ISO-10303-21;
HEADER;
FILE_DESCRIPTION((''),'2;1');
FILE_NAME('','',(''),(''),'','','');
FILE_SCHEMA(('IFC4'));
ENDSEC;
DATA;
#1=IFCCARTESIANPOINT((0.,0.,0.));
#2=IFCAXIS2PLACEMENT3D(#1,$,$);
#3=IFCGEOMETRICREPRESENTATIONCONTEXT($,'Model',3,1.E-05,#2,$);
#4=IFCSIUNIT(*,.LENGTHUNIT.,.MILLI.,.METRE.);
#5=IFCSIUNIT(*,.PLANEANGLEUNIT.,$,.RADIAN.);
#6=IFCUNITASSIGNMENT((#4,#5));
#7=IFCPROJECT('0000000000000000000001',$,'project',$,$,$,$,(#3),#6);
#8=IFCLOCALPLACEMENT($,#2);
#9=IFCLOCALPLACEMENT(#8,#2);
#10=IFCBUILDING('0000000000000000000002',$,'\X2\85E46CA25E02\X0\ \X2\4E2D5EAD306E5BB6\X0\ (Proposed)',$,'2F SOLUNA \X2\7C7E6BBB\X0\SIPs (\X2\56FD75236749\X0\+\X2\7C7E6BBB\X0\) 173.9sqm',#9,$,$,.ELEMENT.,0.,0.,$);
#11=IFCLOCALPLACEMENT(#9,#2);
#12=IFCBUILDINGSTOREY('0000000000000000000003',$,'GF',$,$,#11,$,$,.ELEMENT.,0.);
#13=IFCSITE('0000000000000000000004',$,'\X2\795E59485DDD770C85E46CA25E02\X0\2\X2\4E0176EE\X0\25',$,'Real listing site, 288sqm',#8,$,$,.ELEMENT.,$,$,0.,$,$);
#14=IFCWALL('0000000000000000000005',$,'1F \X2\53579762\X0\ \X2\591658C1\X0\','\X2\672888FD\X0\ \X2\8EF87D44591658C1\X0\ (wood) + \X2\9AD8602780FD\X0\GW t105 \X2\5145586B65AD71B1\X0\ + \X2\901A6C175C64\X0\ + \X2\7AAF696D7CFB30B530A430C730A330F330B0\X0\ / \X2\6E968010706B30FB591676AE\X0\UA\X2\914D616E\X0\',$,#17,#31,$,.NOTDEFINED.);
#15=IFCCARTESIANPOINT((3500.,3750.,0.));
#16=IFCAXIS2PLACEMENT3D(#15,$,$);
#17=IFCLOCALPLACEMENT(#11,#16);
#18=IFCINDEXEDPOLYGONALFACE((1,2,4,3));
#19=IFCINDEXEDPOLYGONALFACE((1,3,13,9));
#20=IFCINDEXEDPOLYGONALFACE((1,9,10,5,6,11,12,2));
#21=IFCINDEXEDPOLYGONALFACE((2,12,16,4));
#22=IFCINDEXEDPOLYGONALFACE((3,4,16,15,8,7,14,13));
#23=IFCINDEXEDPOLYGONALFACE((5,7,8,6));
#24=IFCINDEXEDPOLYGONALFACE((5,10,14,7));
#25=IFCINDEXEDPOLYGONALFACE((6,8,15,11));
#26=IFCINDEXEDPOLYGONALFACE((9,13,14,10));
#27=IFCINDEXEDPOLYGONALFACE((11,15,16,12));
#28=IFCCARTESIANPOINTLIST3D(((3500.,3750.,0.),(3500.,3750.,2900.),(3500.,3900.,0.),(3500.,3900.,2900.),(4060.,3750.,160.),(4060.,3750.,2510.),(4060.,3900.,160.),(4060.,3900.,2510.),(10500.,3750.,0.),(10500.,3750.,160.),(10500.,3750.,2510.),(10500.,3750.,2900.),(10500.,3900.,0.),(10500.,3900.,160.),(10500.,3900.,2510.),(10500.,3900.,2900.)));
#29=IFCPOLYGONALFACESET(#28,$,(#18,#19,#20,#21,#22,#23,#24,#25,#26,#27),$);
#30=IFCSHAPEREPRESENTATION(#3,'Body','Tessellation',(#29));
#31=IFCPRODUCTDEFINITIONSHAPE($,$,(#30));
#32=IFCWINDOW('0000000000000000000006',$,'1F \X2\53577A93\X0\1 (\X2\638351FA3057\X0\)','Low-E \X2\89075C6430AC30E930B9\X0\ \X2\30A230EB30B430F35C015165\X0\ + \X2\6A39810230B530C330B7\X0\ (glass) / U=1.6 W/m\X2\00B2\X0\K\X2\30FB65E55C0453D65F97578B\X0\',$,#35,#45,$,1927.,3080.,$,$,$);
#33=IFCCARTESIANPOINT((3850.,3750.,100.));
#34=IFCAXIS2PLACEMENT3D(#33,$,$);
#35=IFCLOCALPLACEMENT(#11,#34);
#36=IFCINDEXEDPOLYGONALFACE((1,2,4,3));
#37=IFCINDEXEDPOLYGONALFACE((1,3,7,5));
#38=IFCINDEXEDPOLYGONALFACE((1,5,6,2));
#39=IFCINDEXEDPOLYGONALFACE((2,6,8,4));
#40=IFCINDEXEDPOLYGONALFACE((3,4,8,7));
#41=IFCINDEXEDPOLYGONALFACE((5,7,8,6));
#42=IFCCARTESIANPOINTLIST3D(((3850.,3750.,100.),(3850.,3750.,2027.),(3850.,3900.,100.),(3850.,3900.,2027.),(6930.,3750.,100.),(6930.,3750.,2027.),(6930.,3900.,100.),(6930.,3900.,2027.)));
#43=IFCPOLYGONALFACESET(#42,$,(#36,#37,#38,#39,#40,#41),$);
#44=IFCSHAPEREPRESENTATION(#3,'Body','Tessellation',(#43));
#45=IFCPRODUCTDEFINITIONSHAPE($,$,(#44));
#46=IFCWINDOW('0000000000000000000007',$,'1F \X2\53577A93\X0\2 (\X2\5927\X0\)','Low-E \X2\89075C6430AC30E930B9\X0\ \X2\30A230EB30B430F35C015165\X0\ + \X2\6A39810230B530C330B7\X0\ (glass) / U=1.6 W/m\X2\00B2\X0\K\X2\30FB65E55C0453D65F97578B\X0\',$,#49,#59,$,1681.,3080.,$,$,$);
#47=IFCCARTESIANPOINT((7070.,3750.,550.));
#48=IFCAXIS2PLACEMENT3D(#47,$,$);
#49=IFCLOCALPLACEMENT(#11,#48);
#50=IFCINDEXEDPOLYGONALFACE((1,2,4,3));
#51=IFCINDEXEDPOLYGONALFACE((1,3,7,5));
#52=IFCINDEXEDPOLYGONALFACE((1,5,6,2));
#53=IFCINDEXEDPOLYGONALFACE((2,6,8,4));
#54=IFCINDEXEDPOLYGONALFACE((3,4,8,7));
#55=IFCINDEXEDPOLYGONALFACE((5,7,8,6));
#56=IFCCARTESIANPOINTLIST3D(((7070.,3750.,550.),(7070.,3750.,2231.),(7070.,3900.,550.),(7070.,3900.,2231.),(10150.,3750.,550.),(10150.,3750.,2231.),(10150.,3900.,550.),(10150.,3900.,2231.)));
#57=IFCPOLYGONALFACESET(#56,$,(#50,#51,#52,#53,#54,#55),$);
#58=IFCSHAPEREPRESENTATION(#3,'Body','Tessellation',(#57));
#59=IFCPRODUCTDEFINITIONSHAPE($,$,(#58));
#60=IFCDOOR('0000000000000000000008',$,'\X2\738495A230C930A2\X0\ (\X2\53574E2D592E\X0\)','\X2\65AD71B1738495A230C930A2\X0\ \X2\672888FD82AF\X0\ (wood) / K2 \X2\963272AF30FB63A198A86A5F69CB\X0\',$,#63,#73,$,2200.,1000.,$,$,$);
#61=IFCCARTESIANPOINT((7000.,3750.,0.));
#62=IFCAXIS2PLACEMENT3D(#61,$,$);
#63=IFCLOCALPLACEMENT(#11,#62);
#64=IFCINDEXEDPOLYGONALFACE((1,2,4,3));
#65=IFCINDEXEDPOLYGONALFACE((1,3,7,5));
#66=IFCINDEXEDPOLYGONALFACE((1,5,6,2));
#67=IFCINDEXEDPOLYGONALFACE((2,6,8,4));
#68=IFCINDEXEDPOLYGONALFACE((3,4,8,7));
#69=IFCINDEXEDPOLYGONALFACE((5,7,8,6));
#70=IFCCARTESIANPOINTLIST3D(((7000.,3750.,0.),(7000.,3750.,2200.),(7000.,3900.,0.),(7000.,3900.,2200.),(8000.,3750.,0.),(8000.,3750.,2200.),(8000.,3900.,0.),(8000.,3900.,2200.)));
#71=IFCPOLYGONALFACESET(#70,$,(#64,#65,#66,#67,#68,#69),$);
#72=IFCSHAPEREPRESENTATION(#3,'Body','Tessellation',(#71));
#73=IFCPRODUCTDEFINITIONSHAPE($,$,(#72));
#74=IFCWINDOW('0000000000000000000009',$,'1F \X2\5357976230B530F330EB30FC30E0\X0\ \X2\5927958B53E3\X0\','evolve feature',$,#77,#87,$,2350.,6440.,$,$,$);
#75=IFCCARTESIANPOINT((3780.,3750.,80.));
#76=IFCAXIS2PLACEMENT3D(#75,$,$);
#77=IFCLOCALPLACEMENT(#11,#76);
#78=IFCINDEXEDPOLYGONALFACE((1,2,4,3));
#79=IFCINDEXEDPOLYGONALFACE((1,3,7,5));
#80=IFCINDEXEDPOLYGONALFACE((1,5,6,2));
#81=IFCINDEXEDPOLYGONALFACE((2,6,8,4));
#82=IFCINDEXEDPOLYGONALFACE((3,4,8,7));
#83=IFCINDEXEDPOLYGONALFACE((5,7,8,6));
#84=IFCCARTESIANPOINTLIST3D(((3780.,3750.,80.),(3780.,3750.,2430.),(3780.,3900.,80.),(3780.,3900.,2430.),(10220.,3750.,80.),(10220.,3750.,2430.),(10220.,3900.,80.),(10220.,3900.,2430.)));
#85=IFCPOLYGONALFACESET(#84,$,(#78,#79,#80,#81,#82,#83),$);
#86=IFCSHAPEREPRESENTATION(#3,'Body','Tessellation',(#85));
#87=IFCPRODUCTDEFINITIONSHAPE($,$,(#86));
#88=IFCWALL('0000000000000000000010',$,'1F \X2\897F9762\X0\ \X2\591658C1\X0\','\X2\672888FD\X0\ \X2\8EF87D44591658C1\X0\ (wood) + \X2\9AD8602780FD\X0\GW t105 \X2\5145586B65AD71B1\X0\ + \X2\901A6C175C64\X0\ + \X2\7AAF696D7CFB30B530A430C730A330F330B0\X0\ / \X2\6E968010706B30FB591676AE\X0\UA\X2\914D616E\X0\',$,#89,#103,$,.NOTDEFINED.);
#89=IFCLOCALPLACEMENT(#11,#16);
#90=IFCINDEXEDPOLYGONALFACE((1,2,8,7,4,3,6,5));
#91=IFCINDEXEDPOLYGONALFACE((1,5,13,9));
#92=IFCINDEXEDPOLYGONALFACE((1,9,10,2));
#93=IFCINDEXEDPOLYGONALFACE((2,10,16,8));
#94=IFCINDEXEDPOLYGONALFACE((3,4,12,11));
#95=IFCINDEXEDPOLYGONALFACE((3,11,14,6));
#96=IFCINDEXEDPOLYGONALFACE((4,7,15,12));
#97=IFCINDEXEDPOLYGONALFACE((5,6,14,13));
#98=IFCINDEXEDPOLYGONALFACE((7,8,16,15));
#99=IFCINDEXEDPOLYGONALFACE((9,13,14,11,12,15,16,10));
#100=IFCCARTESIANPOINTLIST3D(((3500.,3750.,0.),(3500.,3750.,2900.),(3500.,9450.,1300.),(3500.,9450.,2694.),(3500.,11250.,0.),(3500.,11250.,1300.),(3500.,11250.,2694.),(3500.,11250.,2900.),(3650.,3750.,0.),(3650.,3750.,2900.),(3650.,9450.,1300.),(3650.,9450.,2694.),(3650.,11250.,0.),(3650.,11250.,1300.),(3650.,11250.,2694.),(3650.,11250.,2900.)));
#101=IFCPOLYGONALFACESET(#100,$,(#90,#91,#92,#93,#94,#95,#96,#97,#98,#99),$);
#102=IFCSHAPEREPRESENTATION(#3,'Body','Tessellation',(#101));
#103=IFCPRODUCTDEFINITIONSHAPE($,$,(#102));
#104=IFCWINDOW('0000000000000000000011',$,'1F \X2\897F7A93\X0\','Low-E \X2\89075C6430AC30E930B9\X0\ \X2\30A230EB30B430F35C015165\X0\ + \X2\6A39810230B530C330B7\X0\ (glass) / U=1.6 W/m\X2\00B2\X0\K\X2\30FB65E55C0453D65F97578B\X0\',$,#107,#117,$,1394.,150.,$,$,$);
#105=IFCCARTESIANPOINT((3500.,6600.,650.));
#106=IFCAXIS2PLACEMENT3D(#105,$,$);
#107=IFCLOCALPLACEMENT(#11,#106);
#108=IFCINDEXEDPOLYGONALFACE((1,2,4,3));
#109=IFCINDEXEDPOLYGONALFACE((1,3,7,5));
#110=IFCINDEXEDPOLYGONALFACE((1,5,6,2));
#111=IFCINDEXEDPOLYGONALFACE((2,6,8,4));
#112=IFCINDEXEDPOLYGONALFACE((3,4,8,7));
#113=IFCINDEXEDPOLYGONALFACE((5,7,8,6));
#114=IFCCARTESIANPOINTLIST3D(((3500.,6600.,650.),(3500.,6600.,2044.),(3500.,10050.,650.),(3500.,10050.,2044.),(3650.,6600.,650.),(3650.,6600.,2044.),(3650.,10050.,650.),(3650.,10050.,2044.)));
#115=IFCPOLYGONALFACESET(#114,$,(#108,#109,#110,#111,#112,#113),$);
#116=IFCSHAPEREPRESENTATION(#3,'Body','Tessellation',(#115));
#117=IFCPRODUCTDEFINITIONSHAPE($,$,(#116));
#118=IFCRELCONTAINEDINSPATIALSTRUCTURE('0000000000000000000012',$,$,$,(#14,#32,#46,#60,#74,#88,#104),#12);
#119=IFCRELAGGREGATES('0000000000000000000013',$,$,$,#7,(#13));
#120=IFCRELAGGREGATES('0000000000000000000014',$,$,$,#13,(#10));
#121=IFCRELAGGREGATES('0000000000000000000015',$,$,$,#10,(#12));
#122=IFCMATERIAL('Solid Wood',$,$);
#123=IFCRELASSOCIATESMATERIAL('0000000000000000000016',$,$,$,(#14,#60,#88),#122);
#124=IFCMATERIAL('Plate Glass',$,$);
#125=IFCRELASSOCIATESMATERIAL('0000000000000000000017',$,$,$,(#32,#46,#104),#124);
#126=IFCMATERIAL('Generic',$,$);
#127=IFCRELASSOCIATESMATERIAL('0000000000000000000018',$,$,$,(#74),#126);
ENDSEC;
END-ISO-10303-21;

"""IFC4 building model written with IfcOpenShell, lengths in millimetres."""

from ifc_helpers import new_model, si_unit, frame, frame_2d, origin, place, context, project, spatial, rectangle, extrude, material, element, fill, save


model = new_model("IFC4")

# Units and contexts
model_context = context("Model", 3, precision=1e-05, world=origin())
ifc_project = project(units=[si_unit("LENGTHUNIT", "METRE", prefix="MILLI"), si_unit("PLANEANGLEUNIT", "RADIAN")], contexts=[model_context])

# Site, building, storey
site_placement = place(None, origin())
site = spatial("IfcSite", under=ifc_project, at=site_placement, Name="神奈川県藤沢市2丁目25", ObjectType="Real listing site, 288sqm", CompositionType="ELEMENT", RefElevation=0.0)
building_placement = place(site_placement, origin())
building = spatial("IfcBuilding", under=site, at=building_placement, Name="藤沢市 中庭の家 (Proposed)", ObjectType="2F SOLUNA 籾殻SIPs (国産杉+籾殻) 173.9sqm", CompositionType="ELEMENT", ElevationOfRefHeight=0.0, ElevationOfTerrain=0.0)
storey_placement = place(building_placement, origin())
storey = spatial("IfcBuildingStorey", under=building, at=storey_placement, Name="GF", CompositionType="ELEMENT", Elevation=0.0)

# Shared definitions
ifc_material_1 = material(Name="Solid Wood")
ifc_material_2 = material(Name="Generic")

# Wall, openings, windows, door
wall_1_placement = place(storey_placement, frame((3500.0, 3750.0, 0.0)))
wall_1 = element("IfcWall", 1, at=wall_1_placement, inside=storey, material=ifc_material_1, Name="1F 南面 外壁", Description="木製 軸組外壁 (wood) + 高性能GW t105 充填断熱 + 通気層 + 窯業系サイディング / 準耐火・外皮UA配慮", PredefinedType="NOTDEFINED", context=model_context, shape_type="SweptSolid", body=[
    extrude(rectangle(XDim=7000.0, YDim=150.0, at=frame_2d((3500.0, 75.0))), frame((3500.0, 3750.0, 0.0)), (0.0, 0.0, 1.0), 2900.0),
])
opening_1_placement = place(storey_placement, frame((3850.0, 3750.0, 100.0)))
opening_1 = element("IfcOpeningElement", 2, at=opening_1_placement, cuts=wall_1, PredefinedType="NOTDEFINED", context=model_context, shape_type="SweptSolid", body=[
    extrude(rectangle(XDim=3080.0, YDim=150.0, at=frame_2d((1540.0, 75.0))), frame((3850.0, 3750.0, 100.0)), (0.0, 0.0, 1.0), 1927.0),
])
opening_2_placement = place(storey_placement, frame((7070.0, 3750.0, 550.0)))
opening_2 = element("IfcOpeningElement", 3, at=opening_2_placement, cuts=wall_1, PredefinedType="NOTDEFINED", context=model_context, shape_type="SweptSolid", body=[
    extrude(rectangle(XDim=3080.0, YDim=150.0, at=frame_2d((1540.0, 75.0))), frame((7070.0, 3750.0, 550.0)), (0.0, 0.0, 1.0), 1681.0),
])
opening_3_placement = place(storey_placement, frame((7000.0, 3750.0, 0.0)))
opening_3 = element("IfcOpeningElement", 4, at=opening_3_placement, cuts=wall_1, PredefinedType="NOTDEFINED", context=model_context, shape_type="SweptSolid", body=[
    extrude(rectangle(XDim=1000.0, YDim=150.0, at=frame_2d((500.0, 75.0))), frame((7000.0, 3750.0, 0.0)), (0.0, 0.0, 1.0), 2200.0),
])
opening_4_placement = place(storey_placement, frame((3780.0, 3750.0, 80.0)))
opening_4 = element("IfcOpeningElement", 5, at=opening_4_placement, cuts=wall_1, PredefinedType="NOTDEFINED", context=model_context, shape_type="SweptSolid", body=[
    extrude(rectangle(XDim=6440.0, YDim=150.0, at=frame_2d((3220.0, 75.0))), frame((3780.0, 3750.0, 80.0)), (0.0, 0.0, 1.0), 2350.0),
])
ifc_material_3 = material(Name="Plate Glass")
window_1_placement = place(storey_placement, frame((3850.0, 3750.0, 100.0)))
window_1 = element("IfcWindow", 6, at=window_1_placement, inside=storey, material=ifc_material_3, Name="1F 南窓1 (掃出し)", Description="Low-E 複層ガラス アルゴン封入 + 樹脂サッシ (glass) / U=1.6 W/m²K・日射取得型", OverallHeight=1927.0, OverallWidth=3080.0, context=model_context, shape_type="SweptSolid", body=[
    extrude(rectangle(XDim=3080.0, YDim=150.0, at=frame_2d((1540.0, 75.0))), frame((3850.0, 3750.0, 100.0)), (0.0, 0.0, 1.0), 1927.0),
])
fill(opening_1, window_1)
window_2_placement = place(storey_placement, frame((7070.0, 3750.0, 550.0)))
window_2 = element("IfcWindow", 7, at=window_2_placement, inside=storey, material=ifc_material_3, Name="1F 南窓2 (大)", Description="Low-E 複層ガラス アルゴン封入 + 樹脂サッシ (glass) / U=1.6 W/m²K・日射取得型", OverallHeight=1681.0, OverallWidth=3080.0, context=model_context, shape_type="SweptSolid", body=[
    extrude(rectangle(XDim=3080.0, YDim=150.0, at=frame_2d((1540.0, 75.0))), frame((7070.0, 3750.0, 550.0)), (0.0, 0.0, 1.0), 1681.0),
])
fill(opening_2, window_2)
door_placement = place(storey_placement, frame((7000.0, 3750.0, 0.0)))
door = element("IfcDoor", 8, at=door_placement, inside=storey, material=ifc_material_1, Name="玄関ドア (南中央)", Description="断熱玄関ドア 木製芯 (wood) / K2 防犯・採風機構", OverallHeight=2200.0, OverallWidth=1000.0, context=model_context, shape_type="SweptSolid", body=[
    extrude(rectangle(XDim=1000.0, YDim=150.0, at=frame_2d((500.0, 75.0))), frame((7000.0, 3750.0, 0.0)), (0.0, 0.0, 1.0), 2200.0),
])
fill(opening_3, door)
window_3_placement = place(storey_placement, frame((3780.0, 3750.0, 80.0)))
window_3 = element("IfcWindow", 9, at=window_3_placement, inside=storey, material=ifc_material_2, Name="1F 南面サンルーム 大開口", Description="evolve feature", OverallHeight=2350.0, OverallWidth=6440.0, context=model_context, shape_type="SweptSolid", body=[
    extrude(rectangle(XDim=6440.0, YDim=150.0, at=frame_2d((3220.0, 75.0))), frame((3780.0, 3750.0, 80.0)), (0.0, 0.0, 1.0), 2350.0),
])
fill(opening_4, window_3)

# Wall, opening, window
wall_2_placement = place(storey_placement, frame((3500.0, 3750.0, 0.0)))
wall_2 = element("IfcWall", 10, at=wall_2_placement, inside=storey, material=ifc_material_1, Name="1F 西面 外壁", Description="木製 軸組外壁 (wood) + 高性能GW t105 充填断熱 + 通気層 + 窯業系サイディング / 準耐火・外皮UA配慮", PredefinedType="NOTDEFINED", context=model_context, shape_type="SweptSolid", body=[
    extrude(rectangle(XDim=150.0, YDim=7500.0, at=frame_2d((75.0, 3750.0))), frame((3500.0, 3750.0, 0.0)), (0.0, 0.0, 1.0), 2900.0),
])
opening_5_placement = place(storey_placement, frame((3500.0, 6600.0, 650.0)))
opening_5 = element("IfcOpeningElement", 11, at=opening_5_placement, cuts=wall_2, PredefinedType="NOTDEFINED", context=model_context, shape_type="SweptSolid", body=[
    extrude(rectangle(XDim=150.0, YDim=3450.0, at=frame_2d((75.0, 1725.0))), frame((3500.0, 6600.0, 650.0)), (0.0, 0.0, 1.0), 1394.0),
])
window_4_placement = place(storey_placement, frame((3500.0, 6600.0, 650.0)))
window_4 = element("IfcWindow", 12, at=window_4_placement, inside=storey, material=ifc_material_3, Name="1F 西窓", Description="Low-E 複層ガラス アルゴン封入 + 樹脂サッシ (glass) / U=1.6 W/m²K・日射取得型", OverallHeight=1394.0, OverallWidth=150.0, context=model_context, shape_type="SweptSolid", body=[
    extrude(rectangle(XDim=150.0, YDim=3450.0, at=frame_2d((75.0, 1725.0))), frame((3500.0, 6600.0, 650.0)), (0.0, 0.0, 1.0), 1394.0),
])
fill(opening_5, window_4)

save(model, "model.ifc")
